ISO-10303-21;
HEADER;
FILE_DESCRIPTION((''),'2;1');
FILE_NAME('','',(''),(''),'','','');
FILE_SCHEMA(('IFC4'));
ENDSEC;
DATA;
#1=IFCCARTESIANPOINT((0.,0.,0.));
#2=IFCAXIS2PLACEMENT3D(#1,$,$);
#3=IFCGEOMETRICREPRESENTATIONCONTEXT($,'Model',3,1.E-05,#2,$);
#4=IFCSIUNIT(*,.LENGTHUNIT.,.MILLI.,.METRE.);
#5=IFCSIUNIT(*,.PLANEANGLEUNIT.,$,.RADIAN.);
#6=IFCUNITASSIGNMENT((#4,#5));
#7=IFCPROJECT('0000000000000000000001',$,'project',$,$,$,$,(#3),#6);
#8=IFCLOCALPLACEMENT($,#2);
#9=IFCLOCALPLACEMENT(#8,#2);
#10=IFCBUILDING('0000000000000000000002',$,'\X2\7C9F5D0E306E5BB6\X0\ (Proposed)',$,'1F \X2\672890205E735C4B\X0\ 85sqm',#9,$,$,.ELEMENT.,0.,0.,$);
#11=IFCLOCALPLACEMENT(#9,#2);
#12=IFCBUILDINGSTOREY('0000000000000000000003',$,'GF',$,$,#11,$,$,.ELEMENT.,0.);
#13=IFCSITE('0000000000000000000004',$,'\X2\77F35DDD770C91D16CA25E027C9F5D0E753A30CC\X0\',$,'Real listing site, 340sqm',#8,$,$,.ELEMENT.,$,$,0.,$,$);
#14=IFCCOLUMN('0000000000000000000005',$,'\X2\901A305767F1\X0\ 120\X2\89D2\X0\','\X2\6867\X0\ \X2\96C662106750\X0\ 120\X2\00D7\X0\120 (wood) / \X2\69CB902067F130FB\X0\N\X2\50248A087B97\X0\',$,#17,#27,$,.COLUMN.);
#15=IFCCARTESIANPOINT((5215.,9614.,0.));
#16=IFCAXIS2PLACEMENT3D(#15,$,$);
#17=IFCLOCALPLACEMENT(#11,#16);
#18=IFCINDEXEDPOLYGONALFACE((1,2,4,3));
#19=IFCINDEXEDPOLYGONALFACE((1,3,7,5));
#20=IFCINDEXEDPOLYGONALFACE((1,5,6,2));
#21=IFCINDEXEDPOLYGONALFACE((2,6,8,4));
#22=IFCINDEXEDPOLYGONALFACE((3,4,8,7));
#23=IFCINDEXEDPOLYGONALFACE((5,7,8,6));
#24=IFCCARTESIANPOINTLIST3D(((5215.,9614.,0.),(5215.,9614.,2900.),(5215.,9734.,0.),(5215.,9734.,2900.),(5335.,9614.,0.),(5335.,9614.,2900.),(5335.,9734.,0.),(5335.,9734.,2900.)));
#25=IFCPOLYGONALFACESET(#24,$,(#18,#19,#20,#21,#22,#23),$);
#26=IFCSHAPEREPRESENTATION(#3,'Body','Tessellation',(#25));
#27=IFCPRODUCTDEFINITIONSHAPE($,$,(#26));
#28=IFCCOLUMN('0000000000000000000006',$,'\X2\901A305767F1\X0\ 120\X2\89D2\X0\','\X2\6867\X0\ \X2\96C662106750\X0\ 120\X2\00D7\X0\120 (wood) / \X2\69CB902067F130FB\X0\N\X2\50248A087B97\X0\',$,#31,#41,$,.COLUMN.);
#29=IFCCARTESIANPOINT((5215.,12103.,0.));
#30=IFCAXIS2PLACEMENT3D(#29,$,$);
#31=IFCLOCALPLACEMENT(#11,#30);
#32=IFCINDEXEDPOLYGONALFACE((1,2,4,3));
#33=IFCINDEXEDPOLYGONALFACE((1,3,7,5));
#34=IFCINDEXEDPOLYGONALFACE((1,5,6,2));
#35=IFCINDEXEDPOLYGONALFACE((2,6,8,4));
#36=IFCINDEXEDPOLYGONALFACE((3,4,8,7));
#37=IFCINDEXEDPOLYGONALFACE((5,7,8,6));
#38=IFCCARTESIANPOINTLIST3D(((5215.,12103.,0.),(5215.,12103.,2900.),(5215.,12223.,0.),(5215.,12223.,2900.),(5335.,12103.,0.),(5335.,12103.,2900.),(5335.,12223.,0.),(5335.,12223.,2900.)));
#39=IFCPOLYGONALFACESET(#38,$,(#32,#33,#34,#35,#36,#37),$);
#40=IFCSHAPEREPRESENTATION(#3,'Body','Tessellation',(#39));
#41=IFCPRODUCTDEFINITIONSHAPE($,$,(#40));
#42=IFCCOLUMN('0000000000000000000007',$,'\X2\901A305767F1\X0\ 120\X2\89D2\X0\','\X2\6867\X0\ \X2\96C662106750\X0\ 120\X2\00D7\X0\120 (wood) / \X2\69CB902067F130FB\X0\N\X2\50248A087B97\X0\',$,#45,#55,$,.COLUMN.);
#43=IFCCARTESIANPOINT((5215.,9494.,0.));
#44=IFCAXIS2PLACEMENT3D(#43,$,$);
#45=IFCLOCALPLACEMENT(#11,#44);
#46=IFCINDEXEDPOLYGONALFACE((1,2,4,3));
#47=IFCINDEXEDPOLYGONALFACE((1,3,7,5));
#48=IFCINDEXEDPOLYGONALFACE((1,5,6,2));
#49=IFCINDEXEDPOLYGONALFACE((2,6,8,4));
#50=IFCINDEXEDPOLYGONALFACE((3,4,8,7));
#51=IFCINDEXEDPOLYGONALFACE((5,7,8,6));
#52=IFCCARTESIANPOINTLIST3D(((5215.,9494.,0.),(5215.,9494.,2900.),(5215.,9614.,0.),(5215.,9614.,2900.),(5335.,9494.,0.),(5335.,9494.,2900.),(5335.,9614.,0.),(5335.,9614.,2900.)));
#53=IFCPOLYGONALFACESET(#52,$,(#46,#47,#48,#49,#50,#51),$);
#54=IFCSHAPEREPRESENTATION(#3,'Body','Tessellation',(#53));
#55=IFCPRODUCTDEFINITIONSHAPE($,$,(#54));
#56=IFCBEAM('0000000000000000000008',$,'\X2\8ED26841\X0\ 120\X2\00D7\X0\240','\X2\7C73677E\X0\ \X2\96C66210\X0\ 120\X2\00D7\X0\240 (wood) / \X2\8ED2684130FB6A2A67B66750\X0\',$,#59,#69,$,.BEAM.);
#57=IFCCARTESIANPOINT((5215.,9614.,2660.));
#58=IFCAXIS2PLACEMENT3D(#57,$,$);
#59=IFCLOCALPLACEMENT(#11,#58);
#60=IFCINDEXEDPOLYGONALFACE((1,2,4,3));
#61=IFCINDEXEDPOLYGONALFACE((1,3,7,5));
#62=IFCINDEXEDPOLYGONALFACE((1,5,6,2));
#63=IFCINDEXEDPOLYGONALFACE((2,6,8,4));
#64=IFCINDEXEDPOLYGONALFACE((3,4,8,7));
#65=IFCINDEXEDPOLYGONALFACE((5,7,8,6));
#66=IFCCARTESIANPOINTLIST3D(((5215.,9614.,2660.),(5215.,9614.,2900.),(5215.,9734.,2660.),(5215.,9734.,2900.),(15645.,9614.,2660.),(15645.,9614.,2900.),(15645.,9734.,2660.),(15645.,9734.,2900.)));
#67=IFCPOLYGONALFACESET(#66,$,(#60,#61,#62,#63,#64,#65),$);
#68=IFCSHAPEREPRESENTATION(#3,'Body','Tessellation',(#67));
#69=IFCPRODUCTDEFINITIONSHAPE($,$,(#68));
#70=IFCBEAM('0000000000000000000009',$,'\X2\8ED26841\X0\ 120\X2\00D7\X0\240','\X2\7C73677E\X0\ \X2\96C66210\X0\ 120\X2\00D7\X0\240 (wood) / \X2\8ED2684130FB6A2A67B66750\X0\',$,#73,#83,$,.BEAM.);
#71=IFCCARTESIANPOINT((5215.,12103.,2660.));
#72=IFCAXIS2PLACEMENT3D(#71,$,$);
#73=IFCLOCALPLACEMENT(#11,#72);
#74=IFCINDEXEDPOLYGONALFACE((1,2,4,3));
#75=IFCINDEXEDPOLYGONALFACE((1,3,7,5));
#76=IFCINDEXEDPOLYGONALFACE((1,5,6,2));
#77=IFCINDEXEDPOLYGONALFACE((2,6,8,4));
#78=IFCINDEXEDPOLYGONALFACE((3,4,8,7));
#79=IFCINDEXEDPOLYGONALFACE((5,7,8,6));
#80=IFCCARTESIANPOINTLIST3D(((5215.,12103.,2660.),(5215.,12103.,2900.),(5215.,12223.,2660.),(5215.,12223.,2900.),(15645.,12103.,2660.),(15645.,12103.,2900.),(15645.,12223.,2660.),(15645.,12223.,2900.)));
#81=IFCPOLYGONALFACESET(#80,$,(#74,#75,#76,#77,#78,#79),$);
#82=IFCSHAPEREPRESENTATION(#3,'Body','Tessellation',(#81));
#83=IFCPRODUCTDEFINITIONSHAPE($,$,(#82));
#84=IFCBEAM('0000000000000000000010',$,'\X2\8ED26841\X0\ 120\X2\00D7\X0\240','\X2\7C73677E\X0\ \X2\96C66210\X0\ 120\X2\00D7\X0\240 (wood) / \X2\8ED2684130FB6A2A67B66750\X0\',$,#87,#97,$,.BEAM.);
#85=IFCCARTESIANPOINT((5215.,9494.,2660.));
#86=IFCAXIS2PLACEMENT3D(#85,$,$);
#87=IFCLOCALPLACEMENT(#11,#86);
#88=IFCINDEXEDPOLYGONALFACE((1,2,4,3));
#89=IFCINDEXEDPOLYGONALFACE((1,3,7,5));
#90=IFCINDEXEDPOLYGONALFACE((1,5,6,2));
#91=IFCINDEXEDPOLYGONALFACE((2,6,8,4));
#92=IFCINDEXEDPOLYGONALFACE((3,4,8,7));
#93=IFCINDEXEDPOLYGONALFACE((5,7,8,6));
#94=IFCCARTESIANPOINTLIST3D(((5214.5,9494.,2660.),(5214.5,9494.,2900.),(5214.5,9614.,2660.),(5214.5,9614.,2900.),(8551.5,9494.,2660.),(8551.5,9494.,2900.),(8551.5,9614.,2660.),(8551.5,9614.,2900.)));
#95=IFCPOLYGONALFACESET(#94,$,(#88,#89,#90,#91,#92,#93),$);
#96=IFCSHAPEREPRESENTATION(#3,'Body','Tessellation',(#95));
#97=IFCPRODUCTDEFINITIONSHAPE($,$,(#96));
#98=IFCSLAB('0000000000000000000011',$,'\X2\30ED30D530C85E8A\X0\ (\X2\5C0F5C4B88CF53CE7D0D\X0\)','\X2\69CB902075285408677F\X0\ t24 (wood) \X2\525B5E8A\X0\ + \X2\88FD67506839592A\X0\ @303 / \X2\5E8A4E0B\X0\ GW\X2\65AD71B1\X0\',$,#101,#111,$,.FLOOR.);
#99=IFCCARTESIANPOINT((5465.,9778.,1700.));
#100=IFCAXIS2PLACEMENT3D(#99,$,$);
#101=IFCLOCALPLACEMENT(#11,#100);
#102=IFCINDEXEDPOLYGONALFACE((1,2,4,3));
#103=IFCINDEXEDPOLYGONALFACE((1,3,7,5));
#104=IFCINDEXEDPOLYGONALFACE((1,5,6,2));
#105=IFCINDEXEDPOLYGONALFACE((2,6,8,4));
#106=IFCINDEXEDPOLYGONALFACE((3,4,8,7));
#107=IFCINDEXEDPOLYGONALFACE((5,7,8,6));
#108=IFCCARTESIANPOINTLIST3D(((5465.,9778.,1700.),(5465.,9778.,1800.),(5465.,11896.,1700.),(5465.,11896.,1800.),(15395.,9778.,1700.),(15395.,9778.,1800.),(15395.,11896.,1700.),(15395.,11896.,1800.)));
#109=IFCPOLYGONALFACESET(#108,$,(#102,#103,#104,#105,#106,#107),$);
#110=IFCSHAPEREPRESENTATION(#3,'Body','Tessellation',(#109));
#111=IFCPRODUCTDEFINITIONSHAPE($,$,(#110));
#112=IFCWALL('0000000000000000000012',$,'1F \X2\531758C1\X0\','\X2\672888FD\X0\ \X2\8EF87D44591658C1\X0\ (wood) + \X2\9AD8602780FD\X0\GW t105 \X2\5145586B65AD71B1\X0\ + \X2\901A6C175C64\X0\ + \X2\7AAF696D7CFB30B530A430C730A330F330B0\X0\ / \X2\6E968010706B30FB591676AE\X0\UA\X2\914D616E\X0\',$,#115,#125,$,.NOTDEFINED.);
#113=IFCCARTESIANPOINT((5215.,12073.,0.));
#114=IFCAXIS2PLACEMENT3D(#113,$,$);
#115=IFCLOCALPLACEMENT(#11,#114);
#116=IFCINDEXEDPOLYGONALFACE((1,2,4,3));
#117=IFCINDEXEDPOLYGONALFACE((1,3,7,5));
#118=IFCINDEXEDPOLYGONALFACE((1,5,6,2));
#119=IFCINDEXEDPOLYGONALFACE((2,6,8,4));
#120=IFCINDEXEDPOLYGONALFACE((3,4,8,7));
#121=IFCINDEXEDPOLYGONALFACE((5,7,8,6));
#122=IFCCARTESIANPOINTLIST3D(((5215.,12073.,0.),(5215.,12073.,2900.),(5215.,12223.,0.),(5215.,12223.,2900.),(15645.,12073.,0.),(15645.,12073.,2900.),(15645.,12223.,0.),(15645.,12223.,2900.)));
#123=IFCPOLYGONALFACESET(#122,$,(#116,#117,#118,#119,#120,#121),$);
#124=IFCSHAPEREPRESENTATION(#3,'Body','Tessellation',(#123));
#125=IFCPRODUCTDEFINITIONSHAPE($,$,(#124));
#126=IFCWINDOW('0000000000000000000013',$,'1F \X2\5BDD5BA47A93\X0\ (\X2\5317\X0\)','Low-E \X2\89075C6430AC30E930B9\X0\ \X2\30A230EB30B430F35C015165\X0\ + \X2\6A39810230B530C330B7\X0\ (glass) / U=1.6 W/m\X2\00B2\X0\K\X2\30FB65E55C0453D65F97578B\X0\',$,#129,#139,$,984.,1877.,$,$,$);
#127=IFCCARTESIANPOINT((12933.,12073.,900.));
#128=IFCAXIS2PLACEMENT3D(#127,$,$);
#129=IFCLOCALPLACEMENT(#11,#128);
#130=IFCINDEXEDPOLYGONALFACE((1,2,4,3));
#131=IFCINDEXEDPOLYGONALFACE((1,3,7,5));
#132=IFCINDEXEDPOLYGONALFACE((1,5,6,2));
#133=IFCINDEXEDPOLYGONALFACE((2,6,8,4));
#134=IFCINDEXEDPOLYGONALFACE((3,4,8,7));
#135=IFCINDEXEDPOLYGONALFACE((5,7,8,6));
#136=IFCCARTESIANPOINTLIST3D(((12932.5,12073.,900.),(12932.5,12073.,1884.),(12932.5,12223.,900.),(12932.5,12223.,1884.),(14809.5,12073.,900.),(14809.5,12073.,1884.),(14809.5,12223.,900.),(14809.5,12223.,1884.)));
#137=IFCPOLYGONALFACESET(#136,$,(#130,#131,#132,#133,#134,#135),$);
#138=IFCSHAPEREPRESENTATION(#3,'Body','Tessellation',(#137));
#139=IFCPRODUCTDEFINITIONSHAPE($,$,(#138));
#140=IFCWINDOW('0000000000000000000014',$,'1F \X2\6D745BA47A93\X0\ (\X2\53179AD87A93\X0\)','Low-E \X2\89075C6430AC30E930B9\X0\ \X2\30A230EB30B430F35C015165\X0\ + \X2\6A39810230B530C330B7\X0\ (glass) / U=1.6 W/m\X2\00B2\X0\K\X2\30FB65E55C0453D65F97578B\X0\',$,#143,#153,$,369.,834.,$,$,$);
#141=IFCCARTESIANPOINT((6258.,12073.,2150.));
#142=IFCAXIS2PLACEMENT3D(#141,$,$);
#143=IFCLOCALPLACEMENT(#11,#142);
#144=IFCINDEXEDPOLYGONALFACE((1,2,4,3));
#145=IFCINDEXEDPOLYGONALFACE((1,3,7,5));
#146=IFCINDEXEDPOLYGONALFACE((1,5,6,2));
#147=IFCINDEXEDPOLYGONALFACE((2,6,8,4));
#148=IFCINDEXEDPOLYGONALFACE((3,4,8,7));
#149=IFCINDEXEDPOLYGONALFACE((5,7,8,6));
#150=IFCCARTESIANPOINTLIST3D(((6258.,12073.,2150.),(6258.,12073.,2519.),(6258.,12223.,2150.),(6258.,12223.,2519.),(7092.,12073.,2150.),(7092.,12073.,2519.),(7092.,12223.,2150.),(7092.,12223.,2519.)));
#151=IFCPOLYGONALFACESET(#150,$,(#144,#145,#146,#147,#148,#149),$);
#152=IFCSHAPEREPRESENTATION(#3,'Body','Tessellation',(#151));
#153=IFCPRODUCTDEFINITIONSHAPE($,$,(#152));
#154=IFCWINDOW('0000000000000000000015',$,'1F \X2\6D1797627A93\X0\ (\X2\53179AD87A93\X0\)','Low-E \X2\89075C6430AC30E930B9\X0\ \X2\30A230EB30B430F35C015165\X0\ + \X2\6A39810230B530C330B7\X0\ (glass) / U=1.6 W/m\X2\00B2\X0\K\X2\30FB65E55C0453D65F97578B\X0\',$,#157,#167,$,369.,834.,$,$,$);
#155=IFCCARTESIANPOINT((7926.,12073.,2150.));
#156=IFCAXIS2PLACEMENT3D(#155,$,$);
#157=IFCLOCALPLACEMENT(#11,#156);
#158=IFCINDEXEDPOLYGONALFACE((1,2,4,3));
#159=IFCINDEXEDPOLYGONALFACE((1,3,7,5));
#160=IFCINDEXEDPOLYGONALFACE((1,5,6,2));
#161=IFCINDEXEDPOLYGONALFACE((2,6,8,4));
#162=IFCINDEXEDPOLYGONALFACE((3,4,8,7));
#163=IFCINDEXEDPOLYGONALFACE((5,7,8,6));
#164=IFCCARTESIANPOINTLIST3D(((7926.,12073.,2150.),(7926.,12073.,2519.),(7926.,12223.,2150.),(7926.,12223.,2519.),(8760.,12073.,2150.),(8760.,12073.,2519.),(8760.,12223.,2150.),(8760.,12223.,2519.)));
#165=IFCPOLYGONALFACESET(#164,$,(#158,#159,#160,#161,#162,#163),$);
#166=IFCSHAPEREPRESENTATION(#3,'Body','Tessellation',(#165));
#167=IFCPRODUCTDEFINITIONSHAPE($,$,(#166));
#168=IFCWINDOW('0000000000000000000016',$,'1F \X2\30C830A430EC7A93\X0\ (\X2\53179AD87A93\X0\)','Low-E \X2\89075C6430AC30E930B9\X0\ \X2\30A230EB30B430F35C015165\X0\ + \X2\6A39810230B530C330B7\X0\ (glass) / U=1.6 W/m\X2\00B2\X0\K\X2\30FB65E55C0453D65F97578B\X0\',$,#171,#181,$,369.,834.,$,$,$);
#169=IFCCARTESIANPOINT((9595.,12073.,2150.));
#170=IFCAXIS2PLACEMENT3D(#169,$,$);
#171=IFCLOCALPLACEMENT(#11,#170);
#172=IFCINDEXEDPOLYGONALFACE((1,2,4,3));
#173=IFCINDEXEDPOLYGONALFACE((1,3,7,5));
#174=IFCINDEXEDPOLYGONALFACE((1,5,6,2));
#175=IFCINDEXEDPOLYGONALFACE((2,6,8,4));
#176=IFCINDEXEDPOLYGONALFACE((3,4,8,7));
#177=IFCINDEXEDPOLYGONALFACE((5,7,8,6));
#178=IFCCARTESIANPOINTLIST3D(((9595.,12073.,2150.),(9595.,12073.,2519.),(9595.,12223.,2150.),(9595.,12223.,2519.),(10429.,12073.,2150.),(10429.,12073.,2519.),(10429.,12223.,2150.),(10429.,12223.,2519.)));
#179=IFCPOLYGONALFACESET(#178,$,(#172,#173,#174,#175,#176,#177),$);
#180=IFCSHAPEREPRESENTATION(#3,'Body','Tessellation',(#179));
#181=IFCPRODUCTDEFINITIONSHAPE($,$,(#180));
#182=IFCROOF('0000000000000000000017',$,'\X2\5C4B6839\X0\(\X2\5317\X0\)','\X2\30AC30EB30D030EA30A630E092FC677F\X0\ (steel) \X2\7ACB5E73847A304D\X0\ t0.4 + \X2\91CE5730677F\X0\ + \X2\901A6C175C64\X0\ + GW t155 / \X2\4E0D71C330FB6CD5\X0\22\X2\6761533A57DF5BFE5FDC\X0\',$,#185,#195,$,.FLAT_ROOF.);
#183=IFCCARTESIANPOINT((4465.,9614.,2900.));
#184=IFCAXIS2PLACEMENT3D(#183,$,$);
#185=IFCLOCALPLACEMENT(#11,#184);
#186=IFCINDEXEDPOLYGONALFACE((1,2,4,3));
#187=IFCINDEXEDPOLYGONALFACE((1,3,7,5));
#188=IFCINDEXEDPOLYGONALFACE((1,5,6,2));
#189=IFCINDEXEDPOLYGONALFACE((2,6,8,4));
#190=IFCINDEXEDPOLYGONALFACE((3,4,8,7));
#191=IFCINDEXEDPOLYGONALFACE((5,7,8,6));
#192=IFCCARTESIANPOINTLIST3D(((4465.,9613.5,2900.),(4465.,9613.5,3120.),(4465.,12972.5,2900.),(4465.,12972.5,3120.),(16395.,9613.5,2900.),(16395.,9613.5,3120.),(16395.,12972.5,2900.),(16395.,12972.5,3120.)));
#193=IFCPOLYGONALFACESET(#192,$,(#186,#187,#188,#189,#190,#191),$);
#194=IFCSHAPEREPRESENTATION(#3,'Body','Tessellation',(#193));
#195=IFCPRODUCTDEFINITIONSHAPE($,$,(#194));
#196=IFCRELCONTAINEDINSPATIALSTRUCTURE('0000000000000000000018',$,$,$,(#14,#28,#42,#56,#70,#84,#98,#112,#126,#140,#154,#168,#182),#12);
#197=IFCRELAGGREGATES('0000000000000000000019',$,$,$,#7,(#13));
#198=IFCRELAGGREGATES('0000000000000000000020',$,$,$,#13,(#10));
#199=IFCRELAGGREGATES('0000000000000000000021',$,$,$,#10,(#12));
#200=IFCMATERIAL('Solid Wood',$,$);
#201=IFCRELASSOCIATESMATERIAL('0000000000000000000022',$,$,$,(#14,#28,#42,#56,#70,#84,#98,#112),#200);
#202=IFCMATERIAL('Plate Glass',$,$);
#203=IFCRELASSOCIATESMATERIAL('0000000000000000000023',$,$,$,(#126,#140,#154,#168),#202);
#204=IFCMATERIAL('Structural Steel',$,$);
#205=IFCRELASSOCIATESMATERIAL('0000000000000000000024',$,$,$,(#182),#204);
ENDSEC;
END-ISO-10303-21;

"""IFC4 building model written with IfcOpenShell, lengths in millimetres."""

from ifc_helpers import new_model, si_unit, frame, frame_2d, origin, place, context, project, spatial, rectangle, extrude, material, element, fill, save


model = new_model("IFC4")

# Units and contexts
model_context = context("Model", 3, precision=1e-05, world=origin())
ifc_project = project(units=[si_unit("LENGTHUNIT", "METRE", prefix="MILLI"), si_unit("PLANEANGLEUNIT", "RADIAN")], contexts=[model_context])

# Site, building, storey
site_placement = place(None, origin())
site = spatial("IfcSite", under=ifc_project, at=site_placement, Name="石川県金沢市粟崎町ヌ", ObjectType="Real listing site, 340sqm", CompositionType="ELEMENT", RefElevation=0.0)
building_placement = place(site_placement, origin())
building = spatial("IfcBuilding", under=site, at=building_placement, Name="粟崎の家 (Proposed)", ObjectType="1F 木造平屋 85sqm", CompositionType="ELEMENT", ElevationOfRefHeight=0.0, ElevationOfTerrain=0.0)
storey_placement = place(building_placement, origin())
storey = spatial("IfcBuildingStorey", under=building, at=storey_placement, Name="GF", CompositionType="ELEMENT", Elevation=0.0)

# Columns
ifc_material_1 = material(Name="Solid Wood")
column_1_placement = place(storey_placement, frame((5215.0, 9614.0, 0.0)))
element("IfcColumn", 1, at=column_1_placement, inside=storey, material=ifc_material_1, Name="通し柱 120角", Description="桧 集成材 120×120 (wood) / 構造柱・N値計算", PredefinedType="COLUMN", context=model_context, shape_type="SweptSolid", body=[
    extrude(rectangle(XDim=120.0, YDim=120.0, at=frame_2d((60.0, 60.0))), frame((5215.0, 9614.0, 0.0)), (0.0, 0.0, 1.0), 2900.0),
])
column_2_placement = place(storey_placement, frame((5215.0, 12103.0, 0.0)))
element("IfcColumn", 2, at=column_2_placement, inside=storey, material=ifc_material_1, Name="通し柱 120角", Description="桧 集成材 120×120 (wood) / 構造柱・N値計算", PredefinedType="COLUMN", context=model_context, shape_type="SweptSolid", body=[
    extrude(rectangle(XDim=120.0, YDim=120.0, at=frame_2d((60.0, 60.0))), frame((5215.0, 12103.0, 0.0)), (0.0, 0.0, 1.0), 2900.0),
])
column_3_placement = place(storey_placement, frame((5215.0, 9494.0, 0.0)))
element("IfcColumn", 3, at=column_3_placement, inside=storey, material=ifc_material_1, Name="通し柱 120角", Description="桧 集成材 120×120 (wood) / 構造柱・N値計算", PredefinedType="COLUMN", context=model_context, shape_type="SweptSolid", body=[
    extrude(rectangle(XDim=120.0, YDim=120.0, at=frame_2d((60.0, 60.0))), frame((5215.0, 9494.0, 0.0)), (0.0, 0.0, 1.0), 2900.0),
])

# Beams
beam_1_placement = place(storey_placement, frame((5215.0, 9614.0, 2660.0)))
element("IfcBeam", 4, at=beam_1_placement, inside=storey, material=ifc_material_1, Name="軒桁 120×240", Description="米松 集成 120×240 (wood) / 軒桁・横架材", PredefinedType="BEAM", context=model_context, shape_type="SweptSolid", body=[
    extrude(rectangle(XDim=10430.0, YDim=120.0, at=frame_2d((5215.0, 60.0))), frame((5215.0, 9614.0, 2660.0)), (0.0, 0.0, 1.0), 240.0),
])
beam_2_placement = place(storey_placement, frame((5215.0, 12103.0, 2660.0)))
element("IfcBeam", 5, at=beam_2_placement, inside=storey, material=ifc_material_1, Name="軒桁 120×240", Description="米松 集成 120×240 (wood) / 軒桁・横架材", PredefinedType="BEAM", context=model_context, shape_type="SweptSolid", body=[
    extrude(rectangle(XDim=10430.0, YDim=120.0, at=frame_2d((5215.0, 60.0))), frame((5215.0, 12103.0, 2660.0)), (0.0, 0.0, 1.0), 240.0),
])
beam_3_placement = place(storey_placement, frame((5215.0, 9494.0, 2660.0)))
element("IfcBeam", 6, at=beam_3_placement, inside=storey, material=ifc_material_1, Name="軒桁 120×240", Description="米松 集成 120×240 (wood) / 軒桁・横架材", PredefinedType="BEAM", context=model_context, shape_type="SweptSolid", body=[
    extrude(rectangle(XDim=3337.0, YDim=120.0, at=frame_2d((1668.0, 60.0))), frame((5215.0, 9494.0, 2660.0)), (0.0, 0.0, 1.0), 240.0),
])

# Slab
slab_1_placement = place(storey_placement, frame((5465.0, 9778.0, 1700.0)))
element("IfcSlab", 7, at=slab_1_placement, inside=storey, material=ifc_material_1, Name="ロフト床 (小屋裏収納)", Description="構造用合板 t24 (wood) 剛床 + 製材根太 @303 / 床下 GW断熱", PredefinedType="FLOOR", context=model_context, shape_type="SweptSolid", body=[
    extrude(rectangle(XDim=9930.0, YDim=2118.0, at=frame_2d((4965.0, 1059.0))), frame((5465.0, 9778.0, 1700.0)), (0.0, 0.0, 1.0), 100.0),
])

# Wall, openings, windows
wall_1_placement = place(storey_placement, frame((5215.0, 12073.0, 0.0)))
wall_1 = element("IfcWall", 8, at=wall_1_placement, inside=storey, material=ifc_material_1, Name="1F 北壁", Description="木製 軸組外壁 (wood) + 高性能GW t105 充填断熱 + 通気層 + 窯業系サイディング / 準耐火・外皮UA配慮", PredefinedType="NOTDEFINED", context=model_context, shape_type="SweptSolid", body=[
    extrude(rectangle(XDim=10430.0, YDim=150.0, at=frame_2d((5215.0, 75.0))), frame((5215.0, 12073.0, 0.0)), (0.0, 0.0, 1.0), 2900.0),
])
opening_1_placement = place(storey_placement, frame((12933.0, 12073.0, 900.0)))
opening_1 = element("IfcOpeningElement", 9, at=opening_1_placement, cuts=wall_1, PredefinedType="NOTDEFINED", context=model_context, shape_type="SweptSolid", body=[
    extrude(rectangle(XDim=1877.0, YDim=150.0, at=frame_2d((938.0, 75.0))), frame((12933.0, 12073.0, 900.0)), (0.0, 0.0, 1.0), 984.0),
])
opening_2_placement = place(storey_placement, frame((6258.0, 12073.0, 2150.0)))
opening_2 = element("IfcOpeningElement", 10, at=opening_2_placement, cuts=wall_1, PredefinedType="NOTDEFINED", context=model_context, shape_type="SweptSolid", body=[
    extrude(rectangle(XDim=834.0, YDim=150.0, at=frame_2d((417.0, 75.0))), frame((6258.0, 12073.0, 2150.0)), (0.0, 0.0, 1.0), 369.0),
])
opening_3_placement = place(storey_placement, frame((7926.0, 12073.0, 2150.0)))
opening_3 = element("IfcOpeningElement", 11, at=opening_3_placement, cuts=wall_1, PredefinedType="NOTDEFINED", context=model_context, shape_type="SweptSolid", body=[
    extrude(rectangle(XDim=834.0, YDim=150.0, at=frame_2d((417.0, 75.0))), frame((7926.0, 12073.0, 2150.0)), (0.0, 0.0, 1.0), 369.0),
])
opening_4_placement = place(storey_placement, frame((9595.0, 12073.0, 2150.0)))
opening_4 = element("IfcOpeningElement", 12, at=opening_4_placement, cuts=wall_1, PredefinedType="NOTDEFINED", context=model_context, shape_type="SweptSolid", body=[
    extrude(rectangle(XDim=834.0, YDim=150.0, at=frame_2d((417.0, 75.0))), frame((9595.0, 12073.0, 2150.0)), (0.0, 0.0, 1.0), 369.0),
])
ifc_material_2 = material(Name="Plate Glass")
window_1_placement = place(storey_placement, frame((12933.0, 12073.0, 900.0)))
window_1 = element("IfcWindow", 13, at=window_1_placement, inside=storey, material=ifc_material_2, Name="1F 寝室窓 (北)", Description="Low-E 複層ガラス アルゴン封入 + 樹脂サッシ (glass) / U=1.6 W/m²K・日射取得型", OverallHeight=984.0, OverallWidth=1877.0, context=model_context, shape_type="SweptSolid", body=[
    extrude(rectangle(XDim=1877.0, YDim=150.0, at=frame_2d((938.0, 75.0))), frame((12933.0, 12073.0, 900.0)), (0.0, 0.0, 1.0), 984.0),
])
fill(opening_1, window_1)
window_2_placement = place(storey_placement, frame((6258.0, 12073.0, 2150.0)))
window_2 = element("IfcWindow", 14, at=window_2_placement, inside=storey, material=ifc_material_2, Name="1F 浴室窓 (北高窓)", Description="Low-E 複層ガラス アルゴン封入 + 樹脂サッシ (glass) / U=1.6 W/m²K・日射取得型", OverallHeight=369.0, OverallWidth=834.0, context=model_context, shape_type="SweptSolid", body=[
    extrude(rectangle(XDim=834.0, YDim=150.0, at=frame_2d((417.0, 75.0))), frame((6258.0, 12073.0, 2150.0)), (0.0, 0.0, 1.0), 369.0),
])
fill(opening_2, window_2)
window_3_placement = place(storey_placement, frame((7926.0, 12073.0, 2150.0)))
window_3 = element("IfcWindow", 15, at=window_3_placement, inside=storey, material=ifc_material_2, Name="1F 洗面窓 (北高窓)", Description="Low-E 複層ガラス アルゴン封入 + 樹脂サッシ (glass) / U=1.6 W/m²K・日射取得型", OverallHeight=369.0, OverallWidth=834.0, context=model_context, shape_type="SweptSolid", body=[
    extrude(rectangle(XDim=834.0, YDim=150.0, at=frame_2d((417.0, 75.0))), frame((7926.0, 12073.0, 2150.0)), (0.0, 0.0, 1.0), 369.0),
])
fill(opening_3, window_3)
window_4_placement = place(storey_placement, frame((9595.0, 12073.0, 2150.0)))
window_4 = element("IfcWindow", 16, at=window_4_placement, inside=storey, material=ifc_material_2, Name="1F トイレ窓 (北高窓)", Description="Low-E 複層ガラス アルゴン封入 + 樹脂サッシ (glass) / U=1.6 W/m²K・日射取得型", OverallHeight=369.0, OverallWidth=834.0, context=model_context, shape_type="SweptSolid", body=[
    extrude(rectangle(XDim=834.0, YDim=150.0, at=frame_2d((417.0, 75.0))), frame((9595.0, 12073.0, 2150.0)), (0.0, 0.0, 1.0), 369.0),
])
fill(opening_4, window_4)

# Roof
ifc_material_3 = material(Name="Structural Steel")
roof_placement = place(storey_placement, frame((4465.0, 9614.0, 2900.0)))
element("IfcRoof", 17, at=roof_placement, inside=storey, material=ifc_material_3, Name="屋根(北)", Description="ガルバリウム鋼板 (steel) 立平葺き t0.4 + 野地板 + 通気層 + GW t155 / 不燃・法22条区域対応", PredefinedType="FLAT_ROOF", context=model_context, shape_type="SweptSolid", body=[
    extrude(rectangle(XDim=11930.0, YDim=3359.0, at=frame_2d((5965.0, 1679.0))), frame((4465.0, 9614.0, 2900.0)), (0.0, 0.0, 1.0), 220.0),
])

save(model, "model.ifc")
